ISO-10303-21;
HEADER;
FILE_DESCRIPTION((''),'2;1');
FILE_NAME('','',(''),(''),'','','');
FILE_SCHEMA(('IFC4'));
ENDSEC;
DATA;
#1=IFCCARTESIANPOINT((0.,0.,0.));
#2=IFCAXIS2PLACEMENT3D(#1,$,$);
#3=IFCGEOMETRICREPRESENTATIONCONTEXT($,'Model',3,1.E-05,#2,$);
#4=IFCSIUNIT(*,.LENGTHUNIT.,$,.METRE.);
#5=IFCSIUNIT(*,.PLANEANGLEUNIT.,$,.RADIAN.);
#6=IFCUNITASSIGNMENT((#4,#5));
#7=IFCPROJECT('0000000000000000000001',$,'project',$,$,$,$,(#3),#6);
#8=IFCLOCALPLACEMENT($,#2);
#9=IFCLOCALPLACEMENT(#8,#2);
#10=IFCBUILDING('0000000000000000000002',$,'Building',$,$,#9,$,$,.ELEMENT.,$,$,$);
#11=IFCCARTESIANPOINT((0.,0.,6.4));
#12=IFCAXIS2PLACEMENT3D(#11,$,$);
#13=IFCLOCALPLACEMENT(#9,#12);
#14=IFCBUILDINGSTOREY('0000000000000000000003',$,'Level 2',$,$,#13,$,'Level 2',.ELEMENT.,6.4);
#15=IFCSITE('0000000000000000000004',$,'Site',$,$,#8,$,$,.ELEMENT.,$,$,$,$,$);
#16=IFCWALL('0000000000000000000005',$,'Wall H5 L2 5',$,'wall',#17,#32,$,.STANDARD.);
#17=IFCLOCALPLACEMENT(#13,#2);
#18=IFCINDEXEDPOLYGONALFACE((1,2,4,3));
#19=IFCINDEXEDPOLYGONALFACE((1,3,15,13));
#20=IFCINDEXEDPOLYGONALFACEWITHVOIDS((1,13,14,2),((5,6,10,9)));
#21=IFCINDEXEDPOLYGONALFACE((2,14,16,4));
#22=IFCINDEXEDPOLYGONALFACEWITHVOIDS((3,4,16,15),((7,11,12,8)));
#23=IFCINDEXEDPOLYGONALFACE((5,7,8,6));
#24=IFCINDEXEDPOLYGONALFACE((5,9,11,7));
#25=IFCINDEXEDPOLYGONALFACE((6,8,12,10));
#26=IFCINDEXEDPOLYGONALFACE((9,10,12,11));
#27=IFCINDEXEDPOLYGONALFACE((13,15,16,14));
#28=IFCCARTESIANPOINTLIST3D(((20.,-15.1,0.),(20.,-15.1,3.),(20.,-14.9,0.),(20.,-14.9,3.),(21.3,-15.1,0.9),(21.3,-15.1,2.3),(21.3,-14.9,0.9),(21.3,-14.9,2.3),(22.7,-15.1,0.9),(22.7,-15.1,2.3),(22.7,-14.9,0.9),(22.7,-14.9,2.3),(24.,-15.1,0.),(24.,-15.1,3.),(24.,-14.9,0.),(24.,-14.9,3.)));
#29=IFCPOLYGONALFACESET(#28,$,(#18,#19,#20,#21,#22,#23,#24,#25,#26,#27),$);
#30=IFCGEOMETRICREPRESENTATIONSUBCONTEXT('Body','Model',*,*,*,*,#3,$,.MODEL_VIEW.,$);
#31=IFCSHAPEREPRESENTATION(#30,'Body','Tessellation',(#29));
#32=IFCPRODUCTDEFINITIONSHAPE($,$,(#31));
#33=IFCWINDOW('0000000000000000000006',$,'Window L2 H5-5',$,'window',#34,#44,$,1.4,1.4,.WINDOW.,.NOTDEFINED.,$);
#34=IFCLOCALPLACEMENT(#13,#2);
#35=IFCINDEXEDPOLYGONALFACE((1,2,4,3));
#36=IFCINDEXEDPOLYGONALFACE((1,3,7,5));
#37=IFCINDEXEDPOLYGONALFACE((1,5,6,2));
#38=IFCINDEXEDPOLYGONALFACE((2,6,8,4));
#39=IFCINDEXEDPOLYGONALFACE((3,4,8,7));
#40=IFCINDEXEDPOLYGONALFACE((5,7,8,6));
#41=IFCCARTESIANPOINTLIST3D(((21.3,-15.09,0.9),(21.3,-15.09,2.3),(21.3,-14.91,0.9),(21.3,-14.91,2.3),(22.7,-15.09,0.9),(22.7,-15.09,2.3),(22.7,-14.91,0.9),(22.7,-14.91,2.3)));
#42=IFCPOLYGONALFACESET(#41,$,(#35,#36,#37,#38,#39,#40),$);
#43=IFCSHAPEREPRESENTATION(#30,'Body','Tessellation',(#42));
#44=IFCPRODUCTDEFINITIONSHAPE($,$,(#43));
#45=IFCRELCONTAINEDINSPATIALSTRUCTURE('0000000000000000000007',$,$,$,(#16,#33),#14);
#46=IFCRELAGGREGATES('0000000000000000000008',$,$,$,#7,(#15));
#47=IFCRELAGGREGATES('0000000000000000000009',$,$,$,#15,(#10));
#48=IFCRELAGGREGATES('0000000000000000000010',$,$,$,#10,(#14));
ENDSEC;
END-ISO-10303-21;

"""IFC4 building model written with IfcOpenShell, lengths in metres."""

from ifc_helpers import new_model, si_unit, frame, frame_2d, origin, origin_2d, place, context, subcontext, project, spatial, rectangle, extrude, element, fill, save


model = new_model("IFC4")

# Units and contexts
model_context = context("Model", 3, precision=1e-05, world=origin())
body_context = subcontext(model_context, "Body", "Model", "MODEL_VIEW")
ifc_project = project(units=[si_unit("LENGTHUNIT", "METRE"), si_unit("PLANEANGLEUNIT", "RADIAN")], contexts=[model_context])

# Site, building, storey
site_placement = place(None, origin())
site = spatial("IfcSite", under=ifc_project, at=site_placement, Name="Site", CompositionType="ELEMENT")
building_placement = place(site_placement, origin())
building = spatial("IfcBuilding", under=site, at=building_placement, Name="Building", CompositionType="ELEMENT")
storey_placement = place(building_placement, frame((0.0, 0.0, 6.4)))
storey = spatial("IfcBuildingStorey", under=building, at=storey_placement, Name="Level 2", LongName="Level 2", CompositionType="ELEMENT", Elevation=6.4)

# Wall, opening, window
wall_1_placement = place(storey_placement, frame((20.0, -15.0, 0.0), z_axis=(0.0, 0.0, 1.0), x_axis=(1.0, 0.0, 0.0)))
wall_1 = element("IfcWall", 1, at=wall_1_placement, inside=storey, Name="Wall H5 L2 5", ObjectType="wall", PredefinedType="STANDARD", context=body_context, shape_type="SweptSolid", body=[
    extrude(rectangle(XDim=4.0, YDim=0.2, at=frame_2d((2.0, 0.0))), origin(), (0.0, 0.0, 1.0), 3.0),
])
opening_1_placement = place(storey_placement, frame((22.0, -15.0, 0.9), z_axis=(0.0, 0.0, 1.0), x_axis=(1.0, 0.0, 0.0)))
opening_1 = element("IfcOpeningElement", 2, at=opening_1_placement, cuts=wall_1, ObjectType="Opening", PredefinedType="OPENING", context=body_context, shape_type="SweptSolid", body=[
    extrude(rectangle(XDim=1.4, YDim=0.22, at=origin_2d()), origin(), (0.0, 0.0, 1.0), 1.4),
])
window_1_placement = place(storey_placement, frame((22.0, -15.0, 0.9), z_axis=(0.0, 0.0, 1.0), x_axis=(1.0, 0.0, 0.0)))
window_1 = element("IfcWindow", 3, at=window_1_placement, inside=storey, Name="Window L2 H5-5", ObjectType="window", OverallHeight=1.4, OverallWidth=1.4, PartitioningType="NOTDEFINED", PredefinedType="WINDOW", context=body_context, shape_type="SweptSolid", body=[
    extrude(rectangle(XDim=1.4, YDim=0.18, at=origin_2d()), origin(), (0.0, 0.0, 1.0), 1.4),
])
fill(opening_1, window_1)

save(model, "model.ifc")
